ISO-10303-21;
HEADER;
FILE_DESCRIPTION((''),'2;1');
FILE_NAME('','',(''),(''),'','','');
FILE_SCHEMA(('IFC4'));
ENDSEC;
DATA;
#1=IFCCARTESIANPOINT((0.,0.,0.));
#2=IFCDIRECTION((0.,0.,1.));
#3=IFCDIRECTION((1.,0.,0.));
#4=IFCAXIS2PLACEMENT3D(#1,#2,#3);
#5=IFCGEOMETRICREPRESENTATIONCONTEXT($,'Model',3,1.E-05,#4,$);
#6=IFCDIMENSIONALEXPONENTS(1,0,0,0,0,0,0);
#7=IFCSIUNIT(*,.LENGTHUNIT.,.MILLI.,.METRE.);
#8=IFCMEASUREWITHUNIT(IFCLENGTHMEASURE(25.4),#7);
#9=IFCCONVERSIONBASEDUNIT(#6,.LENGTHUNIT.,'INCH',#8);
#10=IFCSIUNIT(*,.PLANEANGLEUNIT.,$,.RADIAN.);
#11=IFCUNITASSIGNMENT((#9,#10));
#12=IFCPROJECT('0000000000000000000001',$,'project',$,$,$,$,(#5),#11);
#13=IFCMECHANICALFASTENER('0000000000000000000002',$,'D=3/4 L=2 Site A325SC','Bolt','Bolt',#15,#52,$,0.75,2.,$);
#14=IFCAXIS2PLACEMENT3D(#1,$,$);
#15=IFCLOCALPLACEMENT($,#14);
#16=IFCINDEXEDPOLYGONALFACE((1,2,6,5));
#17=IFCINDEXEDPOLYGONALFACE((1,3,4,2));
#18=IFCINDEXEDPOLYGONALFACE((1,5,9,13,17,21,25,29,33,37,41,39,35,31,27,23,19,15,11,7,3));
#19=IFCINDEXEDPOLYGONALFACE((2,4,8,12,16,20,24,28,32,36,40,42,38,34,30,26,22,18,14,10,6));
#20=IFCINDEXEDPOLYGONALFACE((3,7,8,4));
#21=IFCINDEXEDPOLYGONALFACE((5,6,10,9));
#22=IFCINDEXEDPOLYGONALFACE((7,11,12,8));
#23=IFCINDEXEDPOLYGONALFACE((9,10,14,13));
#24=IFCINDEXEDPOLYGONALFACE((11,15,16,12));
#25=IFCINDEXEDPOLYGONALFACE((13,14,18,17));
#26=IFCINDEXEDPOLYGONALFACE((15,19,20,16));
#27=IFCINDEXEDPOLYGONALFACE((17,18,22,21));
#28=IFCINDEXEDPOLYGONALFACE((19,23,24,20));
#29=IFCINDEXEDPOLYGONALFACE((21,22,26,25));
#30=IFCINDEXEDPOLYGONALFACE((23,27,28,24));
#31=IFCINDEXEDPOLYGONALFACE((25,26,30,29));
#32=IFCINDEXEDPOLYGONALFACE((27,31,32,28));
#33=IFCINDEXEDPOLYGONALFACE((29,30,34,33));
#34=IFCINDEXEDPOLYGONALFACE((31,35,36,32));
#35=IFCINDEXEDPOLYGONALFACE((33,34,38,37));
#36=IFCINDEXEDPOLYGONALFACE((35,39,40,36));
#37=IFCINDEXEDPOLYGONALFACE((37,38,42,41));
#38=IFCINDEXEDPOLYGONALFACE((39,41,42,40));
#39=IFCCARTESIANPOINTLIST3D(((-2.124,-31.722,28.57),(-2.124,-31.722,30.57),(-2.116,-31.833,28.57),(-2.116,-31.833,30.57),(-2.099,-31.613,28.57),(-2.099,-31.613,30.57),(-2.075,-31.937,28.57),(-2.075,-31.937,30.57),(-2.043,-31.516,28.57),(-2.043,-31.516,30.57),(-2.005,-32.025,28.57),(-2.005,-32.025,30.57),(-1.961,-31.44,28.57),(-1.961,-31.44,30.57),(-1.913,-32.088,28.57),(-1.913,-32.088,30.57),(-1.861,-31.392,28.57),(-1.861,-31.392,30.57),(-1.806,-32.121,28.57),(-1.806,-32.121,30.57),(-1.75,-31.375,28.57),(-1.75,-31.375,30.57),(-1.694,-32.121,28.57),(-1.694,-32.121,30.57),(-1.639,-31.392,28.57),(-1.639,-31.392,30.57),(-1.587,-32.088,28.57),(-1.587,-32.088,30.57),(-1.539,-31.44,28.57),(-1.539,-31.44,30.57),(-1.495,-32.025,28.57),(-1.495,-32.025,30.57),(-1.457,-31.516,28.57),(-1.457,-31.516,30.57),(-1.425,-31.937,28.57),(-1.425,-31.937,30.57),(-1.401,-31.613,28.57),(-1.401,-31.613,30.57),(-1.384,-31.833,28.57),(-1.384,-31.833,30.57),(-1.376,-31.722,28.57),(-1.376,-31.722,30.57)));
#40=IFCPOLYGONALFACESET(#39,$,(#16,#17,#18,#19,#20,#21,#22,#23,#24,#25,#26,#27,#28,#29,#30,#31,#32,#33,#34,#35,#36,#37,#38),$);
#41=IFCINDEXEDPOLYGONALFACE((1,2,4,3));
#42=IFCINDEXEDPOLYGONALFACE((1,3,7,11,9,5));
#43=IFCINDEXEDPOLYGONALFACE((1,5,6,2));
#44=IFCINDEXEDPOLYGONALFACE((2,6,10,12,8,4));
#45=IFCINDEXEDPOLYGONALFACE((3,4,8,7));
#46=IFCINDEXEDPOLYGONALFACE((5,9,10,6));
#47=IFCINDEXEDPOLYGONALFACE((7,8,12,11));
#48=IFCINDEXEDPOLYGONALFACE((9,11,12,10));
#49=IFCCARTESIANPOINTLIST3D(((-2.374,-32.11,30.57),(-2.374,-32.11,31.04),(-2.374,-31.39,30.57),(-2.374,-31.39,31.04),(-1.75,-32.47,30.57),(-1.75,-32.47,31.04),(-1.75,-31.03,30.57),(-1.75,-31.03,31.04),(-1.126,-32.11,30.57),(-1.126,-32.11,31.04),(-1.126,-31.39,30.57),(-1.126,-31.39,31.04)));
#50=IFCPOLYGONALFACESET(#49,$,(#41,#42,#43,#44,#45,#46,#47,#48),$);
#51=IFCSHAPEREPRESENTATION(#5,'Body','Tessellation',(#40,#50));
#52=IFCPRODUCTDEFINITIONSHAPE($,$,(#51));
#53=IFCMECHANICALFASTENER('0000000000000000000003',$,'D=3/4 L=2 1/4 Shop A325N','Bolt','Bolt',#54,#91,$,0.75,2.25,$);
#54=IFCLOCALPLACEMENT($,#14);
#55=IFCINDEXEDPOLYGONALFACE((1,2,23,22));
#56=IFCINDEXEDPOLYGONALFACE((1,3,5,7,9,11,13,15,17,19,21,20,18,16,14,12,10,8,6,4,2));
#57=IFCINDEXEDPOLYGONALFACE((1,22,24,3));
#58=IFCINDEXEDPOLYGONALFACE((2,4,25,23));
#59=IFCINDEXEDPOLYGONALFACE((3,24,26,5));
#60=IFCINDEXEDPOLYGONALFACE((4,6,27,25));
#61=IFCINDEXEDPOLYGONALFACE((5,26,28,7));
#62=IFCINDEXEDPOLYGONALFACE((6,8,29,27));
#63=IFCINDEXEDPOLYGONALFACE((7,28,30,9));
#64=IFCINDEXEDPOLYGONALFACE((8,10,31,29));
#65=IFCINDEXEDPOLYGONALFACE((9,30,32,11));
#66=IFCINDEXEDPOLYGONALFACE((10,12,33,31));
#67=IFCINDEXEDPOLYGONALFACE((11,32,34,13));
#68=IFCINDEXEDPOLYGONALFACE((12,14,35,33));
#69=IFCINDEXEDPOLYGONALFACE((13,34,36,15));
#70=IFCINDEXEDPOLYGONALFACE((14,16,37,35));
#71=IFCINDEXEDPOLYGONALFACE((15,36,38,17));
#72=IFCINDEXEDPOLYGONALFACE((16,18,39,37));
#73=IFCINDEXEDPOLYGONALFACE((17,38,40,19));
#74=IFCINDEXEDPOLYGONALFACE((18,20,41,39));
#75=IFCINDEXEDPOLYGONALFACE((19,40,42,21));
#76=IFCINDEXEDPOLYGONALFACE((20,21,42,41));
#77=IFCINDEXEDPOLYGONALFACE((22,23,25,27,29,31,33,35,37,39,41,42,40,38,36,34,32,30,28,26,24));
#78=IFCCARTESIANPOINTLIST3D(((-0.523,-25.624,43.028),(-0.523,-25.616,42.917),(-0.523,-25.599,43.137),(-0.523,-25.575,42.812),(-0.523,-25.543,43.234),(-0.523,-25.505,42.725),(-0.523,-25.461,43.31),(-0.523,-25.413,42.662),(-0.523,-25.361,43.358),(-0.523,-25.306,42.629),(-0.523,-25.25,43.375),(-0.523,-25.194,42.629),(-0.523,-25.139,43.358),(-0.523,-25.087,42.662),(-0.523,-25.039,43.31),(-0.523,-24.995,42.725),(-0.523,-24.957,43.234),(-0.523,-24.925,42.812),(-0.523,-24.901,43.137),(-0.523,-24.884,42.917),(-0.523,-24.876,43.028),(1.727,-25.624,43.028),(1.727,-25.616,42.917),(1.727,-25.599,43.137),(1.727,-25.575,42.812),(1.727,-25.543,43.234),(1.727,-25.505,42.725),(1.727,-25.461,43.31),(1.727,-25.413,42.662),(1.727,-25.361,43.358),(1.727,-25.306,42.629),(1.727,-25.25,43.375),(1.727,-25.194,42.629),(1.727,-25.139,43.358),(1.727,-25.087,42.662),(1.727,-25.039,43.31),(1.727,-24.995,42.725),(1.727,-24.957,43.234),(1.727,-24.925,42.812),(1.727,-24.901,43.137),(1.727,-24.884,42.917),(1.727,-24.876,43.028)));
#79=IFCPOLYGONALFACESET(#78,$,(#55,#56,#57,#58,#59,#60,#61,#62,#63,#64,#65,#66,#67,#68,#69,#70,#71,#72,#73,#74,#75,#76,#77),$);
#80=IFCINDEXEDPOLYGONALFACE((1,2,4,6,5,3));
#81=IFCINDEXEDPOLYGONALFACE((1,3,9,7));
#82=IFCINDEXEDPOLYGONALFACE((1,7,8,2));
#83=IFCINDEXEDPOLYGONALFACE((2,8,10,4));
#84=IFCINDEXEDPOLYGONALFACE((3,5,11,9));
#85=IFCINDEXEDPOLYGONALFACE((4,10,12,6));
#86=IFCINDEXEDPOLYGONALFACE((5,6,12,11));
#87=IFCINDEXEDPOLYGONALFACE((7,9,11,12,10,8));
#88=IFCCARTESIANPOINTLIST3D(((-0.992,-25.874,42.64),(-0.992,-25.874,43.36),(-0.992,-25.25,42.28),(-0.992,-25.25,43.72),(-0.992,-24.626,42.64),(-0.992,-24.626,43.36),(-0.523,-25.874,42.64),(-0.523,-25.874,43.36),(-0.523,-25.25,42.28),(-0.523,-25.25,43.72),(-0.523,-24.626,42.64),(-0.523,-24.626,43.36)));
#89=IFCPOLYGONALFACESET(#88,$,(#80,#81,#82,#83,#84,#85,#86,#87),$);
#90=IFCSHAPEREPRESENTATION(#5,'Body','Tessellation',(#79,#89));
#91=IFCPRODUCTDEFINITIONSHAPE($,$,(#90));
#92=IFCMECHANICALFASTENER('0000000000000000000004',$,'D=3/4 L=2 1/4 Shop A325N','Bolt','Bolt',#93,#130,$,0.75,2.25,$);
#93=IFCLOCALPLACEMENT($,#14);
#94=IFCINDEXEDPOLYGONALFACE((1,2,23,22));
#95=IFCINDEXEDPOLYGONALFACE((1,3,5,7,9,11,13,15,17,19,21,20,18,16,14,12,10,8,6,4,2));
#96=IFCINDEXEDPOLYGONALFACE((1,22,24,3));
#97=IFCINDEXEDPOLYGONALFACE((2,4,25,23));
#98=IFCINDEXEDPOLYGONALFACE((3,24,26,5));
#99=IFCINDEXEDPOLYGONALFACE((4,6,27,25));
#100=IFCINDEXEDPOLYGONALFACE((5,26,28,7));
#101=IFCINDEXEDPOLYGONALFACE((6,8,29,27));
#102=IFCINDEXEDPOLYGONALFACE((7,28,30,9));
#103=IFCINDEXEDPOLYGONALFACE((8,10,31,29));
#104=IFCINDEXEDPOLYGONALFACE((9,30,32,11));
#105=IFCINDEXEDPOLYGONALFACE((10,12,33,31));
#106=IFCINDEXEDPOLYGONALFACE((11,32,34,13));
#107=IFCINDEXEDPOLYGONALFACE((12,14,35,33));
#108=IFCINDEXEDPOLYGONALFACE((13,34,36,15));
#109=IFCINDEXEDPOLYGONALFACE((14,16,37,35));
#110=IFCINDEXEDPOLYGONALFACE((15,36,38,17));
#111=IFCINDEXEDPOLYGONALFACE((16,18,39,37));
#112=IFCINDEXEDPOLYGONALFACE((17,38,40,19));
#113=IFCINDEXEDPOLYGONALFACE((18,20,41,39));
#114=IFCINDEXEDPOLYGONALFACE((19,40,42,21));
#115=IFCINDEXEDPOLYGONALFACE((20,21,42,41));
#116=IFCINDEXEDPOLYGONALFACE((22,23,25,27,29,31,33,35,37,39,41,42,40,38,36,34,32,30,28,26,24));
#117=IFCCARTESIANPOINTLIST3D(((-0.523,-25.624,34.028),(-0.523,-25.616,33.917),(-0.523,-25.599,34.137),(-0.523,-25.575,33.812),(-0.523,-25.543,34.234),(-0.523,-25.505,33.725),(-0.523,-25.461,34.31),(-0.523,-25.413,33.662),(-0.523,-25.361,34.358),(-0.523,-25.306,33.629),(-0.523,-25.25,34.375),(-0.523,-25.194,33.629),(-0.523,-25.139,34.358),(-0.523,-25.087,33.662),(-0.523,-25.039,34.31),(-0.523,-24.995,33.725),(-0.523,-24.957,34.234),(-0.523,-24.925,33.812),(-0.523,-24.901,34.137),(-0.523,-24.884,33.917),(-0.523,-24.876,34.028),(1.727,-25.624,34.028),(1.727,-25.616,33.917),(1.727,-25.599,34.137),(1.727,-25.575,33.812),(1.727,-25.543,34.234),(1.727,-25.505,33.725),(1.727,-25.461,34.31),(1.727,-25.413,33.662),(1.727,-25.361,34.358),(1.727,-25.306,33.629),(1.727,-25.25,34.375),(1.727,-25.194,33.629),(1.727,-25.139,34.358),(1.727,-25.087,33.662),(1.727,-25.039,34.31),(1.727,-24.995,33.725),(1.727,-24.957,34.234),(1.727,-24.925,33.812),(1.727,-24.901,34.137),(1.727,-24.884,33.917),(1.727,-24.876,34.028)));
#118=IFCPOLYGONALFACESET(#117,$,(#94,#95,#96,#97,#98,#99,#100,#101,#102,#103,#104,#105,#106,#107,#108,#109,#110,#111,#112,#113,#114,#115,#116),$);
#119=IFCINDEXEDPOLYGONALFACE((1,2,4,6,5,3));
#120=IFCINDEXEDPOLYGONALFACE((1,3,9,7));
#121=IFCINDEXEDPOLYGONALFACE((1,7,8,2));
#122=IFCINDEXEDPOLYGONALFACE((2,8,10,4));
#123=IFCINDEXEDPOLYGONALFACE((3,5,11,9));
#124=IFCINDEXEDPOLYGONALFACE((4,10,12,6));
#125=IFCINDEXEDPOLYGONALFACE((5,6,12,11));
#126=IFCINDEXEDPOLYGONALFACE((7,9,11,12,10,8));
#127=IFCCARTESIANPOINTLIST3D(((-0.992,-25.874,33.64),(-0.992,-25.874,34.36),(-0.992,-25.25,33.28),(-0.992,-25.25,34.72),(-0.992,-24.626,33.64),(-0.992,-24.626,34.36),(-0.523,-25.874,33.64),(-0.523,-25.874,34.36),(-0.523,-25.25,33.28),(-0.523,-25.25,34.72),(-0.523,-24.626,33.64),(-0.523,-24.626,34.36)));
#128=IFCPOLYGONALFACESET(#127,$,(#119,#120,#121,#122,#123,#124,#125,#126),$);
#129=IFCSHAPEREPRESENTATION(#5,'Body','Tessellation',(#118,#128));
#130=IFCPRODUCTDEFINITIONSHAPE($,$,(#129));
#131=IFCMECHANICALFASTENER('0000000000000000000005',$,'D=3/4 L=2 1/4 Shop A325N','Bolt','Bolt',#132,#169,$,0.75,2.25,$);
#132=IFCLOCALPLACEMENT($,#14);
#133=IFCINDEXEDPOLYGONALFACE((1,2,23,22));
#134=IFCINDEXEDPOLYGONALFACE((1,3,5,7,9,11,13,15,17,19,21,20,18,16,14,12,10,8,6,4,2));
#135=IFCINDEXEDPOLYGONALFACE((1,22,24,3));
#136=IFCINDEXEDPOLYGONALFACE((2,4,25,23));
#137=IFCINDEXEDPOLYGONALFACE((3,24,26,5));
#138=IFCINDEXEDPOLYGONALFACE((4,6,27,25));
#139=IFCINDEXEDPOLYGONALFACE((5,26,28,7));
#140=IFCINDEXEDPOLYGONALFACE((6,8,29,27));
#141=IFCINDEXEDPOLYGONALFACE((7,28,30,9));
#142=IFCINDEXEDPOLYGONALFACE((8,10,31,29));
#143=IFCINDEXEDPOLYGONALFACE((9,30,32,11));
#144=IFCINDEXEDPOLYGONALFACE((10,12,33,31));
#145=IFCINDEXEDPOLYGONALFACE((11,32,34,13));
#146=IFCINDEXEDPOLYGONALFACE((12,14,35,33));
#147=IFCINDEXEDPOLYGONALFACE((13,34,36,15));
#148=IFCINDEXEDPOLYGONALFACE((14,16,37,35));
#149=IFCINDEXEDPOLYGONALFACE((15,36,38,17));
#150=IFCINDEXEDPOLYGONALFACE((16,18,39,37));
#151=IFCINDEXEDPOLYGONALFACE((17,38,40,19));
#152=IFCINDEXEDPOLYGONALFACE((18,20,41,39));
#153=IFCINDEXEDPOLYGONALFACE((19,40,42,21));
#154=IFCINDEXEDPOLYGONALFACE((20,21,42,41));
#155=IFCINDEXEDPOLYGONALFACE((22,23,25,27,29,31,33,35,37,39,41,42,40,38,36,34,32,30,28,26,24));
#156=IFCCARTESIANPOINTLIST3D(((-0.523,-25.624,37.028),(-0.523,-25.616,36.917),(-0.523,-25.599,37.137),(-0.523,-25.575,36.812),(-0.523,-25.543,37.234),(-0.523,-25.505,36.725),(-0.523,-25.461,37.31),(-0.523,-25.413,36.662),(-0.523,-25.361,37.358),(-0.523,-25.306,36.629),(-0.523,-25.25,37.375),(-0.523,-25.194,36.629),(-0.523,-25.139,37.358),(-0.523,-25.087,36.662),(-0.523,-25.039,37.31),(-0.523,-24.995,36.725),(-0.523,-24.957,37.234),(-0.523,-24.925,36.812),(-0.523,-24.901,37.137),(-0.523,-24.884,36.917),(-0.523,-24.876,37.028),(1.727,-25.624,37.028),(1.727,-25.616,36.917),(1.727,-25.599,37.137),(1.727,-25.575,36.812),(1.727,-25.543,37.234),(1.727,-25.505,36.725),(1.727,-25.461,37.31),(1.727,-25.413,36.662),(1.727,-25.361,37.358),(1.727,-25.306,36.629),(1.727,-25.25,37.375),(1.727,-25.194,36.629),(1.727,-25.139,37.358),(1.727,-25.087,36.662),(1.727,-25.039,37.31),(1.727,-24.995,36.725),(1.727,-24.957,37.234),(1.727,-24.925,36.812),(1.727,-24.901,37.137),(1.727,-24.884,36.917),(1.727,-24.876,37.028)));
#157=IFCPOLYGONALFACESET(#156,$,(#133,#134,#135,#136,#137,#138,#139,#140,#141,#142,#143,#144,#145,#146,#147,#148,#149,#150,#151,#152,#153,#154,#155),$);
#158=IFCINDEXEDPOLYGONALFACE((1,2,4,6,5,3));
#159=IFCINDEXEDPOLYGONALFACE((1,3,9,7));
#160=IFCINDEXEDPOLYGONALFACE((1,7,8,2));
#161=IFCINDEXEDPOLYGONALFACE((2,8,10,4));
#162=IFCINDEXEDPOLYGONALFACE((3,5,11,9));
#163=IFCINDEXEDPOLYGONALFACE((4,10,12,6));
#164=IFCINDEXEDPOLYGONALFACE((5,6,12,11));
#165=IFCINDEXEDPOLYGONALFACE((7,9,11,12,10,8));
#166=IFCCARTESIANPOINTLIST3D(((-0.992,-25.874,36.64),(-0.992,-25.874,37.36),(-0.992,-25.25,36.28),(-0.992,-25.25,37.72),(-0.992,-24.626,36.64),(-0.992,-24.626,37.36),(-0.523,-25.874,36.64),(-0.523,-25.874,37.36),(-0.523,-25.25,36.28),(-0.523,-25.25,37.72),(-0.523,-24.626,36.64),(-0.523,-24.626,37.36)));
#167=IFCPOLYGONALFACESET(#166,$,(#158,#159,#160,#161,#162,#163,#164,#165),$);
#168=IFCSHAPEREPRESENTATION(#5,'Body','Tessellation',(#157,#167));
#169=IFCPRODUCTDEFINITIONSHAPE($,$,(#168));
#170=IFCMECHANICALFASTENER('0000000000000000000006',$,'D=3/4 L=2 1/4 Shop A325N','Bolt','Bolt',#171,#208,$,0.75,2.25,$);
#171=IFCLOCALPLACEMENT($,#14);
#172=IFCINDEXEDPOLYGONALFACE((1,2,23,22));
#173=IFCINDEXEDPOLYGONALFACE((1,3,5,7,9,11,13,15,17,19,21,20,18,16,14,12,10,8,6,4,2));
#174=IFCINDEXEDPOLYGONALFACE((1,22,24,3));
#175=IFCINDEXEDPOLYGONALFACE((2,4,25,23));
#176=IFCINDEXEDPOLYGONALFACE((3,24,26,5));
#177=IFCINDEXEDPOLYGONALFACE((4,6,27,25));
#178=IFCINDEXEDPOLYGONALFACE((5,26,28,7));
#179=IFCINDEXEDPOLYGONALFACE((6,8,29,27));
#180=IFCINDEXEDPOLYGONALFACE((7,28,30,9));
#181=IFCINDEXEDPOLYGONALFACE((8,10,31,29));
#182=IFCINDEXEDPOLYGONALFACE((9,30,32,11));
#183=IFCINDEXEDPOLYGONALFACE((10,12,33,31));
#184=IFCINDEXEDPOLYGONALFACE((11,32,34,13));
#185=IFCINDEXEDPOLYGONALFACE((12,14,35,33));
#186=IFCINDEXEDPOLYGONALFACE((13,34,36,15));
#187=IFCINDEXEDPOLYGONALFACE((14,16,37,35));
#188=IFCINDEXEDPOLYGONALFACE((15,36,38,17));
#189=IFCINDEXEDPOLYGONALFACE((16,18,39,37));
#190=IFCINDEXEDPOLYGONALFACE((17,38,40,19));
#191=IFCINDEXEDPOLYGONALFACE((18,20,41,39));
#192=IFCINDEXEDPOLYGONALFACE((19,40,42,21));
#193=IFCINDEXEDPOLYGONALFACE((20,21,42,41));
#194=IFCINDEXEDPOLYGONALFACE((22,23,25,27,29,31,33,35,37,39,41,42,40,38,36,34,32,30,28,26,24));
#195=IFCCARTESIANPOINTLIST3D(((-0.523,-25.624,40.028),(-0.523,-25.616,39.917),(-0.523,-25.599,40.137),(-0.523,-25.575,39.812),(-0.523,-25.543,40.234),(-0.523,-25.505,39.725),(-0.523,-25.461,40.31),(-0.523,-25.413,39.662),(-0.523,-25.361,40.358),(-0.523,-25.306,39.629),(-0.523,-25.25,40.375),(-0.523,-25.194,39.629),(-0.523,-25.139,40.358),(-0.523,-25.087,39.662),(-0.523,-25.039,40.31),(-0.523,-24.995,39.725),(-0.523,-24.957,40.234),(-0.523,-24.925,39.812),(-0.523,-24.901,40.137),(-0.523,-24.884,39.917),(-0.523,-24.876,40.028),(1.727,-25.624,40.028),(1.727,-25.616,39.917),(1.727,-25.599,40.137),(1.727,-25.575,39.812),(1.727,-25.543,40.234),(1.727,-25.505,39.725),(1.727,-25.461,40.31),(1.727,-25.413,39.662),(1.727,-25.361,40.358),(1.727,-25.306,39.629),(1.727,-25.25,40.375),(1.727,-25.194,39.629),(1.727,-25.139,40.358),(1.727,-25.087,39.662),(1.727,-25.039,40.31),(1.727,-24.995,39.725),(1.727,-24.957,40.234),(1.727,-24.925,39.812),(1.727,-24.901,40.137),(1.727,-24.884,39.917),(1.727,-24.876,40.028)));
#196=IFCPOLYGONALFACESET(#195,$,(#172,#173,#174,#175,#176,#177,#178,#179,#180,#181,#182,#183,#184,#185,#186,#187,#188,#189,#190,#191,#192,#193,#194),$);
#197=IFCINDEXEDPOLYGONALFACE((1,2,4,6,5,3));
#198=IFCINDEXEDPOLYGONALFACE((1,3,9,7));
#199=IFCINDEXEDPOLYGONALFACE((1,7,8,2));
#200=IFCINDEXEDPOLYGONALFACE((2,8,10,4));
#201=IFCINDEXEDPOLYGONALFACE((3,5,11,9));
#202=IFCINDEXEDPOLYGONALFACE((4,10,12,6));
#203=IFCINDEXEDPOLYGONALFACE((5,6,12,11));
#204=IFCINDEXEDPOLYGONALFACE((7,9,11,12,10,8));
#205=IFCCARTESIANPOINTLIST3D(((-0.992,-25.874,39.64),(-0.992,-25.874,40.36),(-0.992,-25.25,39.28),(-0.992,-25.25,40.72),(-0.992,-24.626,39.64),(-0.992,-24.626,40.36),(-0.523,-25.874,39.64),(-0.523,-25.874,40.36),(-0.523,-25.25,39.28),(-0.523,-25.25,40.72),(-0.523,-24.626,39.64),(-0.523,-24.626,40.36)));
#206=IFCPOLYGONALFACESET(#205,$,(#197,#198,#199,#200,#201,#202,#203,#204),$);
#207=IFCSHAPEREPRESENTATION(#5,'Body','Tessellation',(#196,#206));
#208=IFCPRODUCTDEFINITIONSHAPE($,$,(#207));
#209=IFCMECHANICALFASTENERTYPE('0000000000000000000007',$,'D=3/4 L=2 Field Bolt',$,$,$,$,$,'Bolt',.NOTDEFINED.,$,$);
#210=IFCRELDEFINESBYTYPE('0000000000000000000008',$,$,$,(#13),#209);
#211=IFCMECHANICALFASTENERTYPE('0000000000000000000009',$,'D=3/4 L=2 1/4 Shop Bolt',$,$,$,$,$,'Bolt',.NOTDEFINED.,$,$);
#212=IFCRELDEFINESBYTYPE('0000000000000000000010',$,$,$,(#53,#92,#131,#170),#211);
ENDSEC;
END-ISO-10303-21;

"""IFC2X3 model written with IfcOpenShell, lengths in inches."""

from ifc_helpers import new_model, entity, si_unit, converted_unit, frame, origin_with_axes, origin_2d_with_axis, place, context, project, polyline, circle, outline, extrude, source, transform, mapped, type_object, type_shapes, element, save


model = new_model("IFC2X3")

# Units and contexts
model_context = context("Model", 3, precision=1e-05, world=origin_with_axes())
ifc_project = project(units=[converted_unit("LENGTHUNIT", "INCH", entity("IfcLengthMeasure", 25.4), si_unit("LENGTHUNIT", "METRE", prefix="MILLI"), dimensions=[1, 0, 0, 0, 0, 0, 0]), si_unit("PLANEANGLEUNIT", "RADIAN")], contexts=[model_context])

# Mechanical fasteners
placement_1 = place(None, origin_with_axes())
placement_2 = place(placement_1, origin_with_axes())
placement_3 = place(placement_2, frame((0.0, 0.0, 46.0), z_axis=(0.0, 0.0, 1.0), x_axis=(0.0, -1.0, 0.0)))
mechanical_fastener_type_1 = type_object("IfcMechanicalFastenerType", Name="D=3/4 L=2 Field Bolt", ElementType="Bolt")
shared_shape_1 = source(origin_with_axes(), model_context, "Body", "SweptSolid", [
    extrude(circle(Radius=0.375, at=origin_2d_with_axis()), frame((0.0, 0.0, 0.0), z_axis=(1.0, 0.0, 0.0), x_axis=(0.0, 1.0, 0.0)), (0.0, 0.0, 1.0), 2.0),
    extrude(outline(polyline([(-0.72, 0.0), (-0.36, 0.624), (0.36, 0.624), (0.72, 0.0), (0.36, -0.624), (-0.36, -0.624), (-0.72, 0.0)])), frame((0.0, 0.0, 0.0), z_axis=(1.0, 0.0, 0.0), x_axis=(0.0, 1.0, 0.0)), (0.0, 0.0, -1.0), 0.47),
])
type_shapes(mechanical_fastener_type_1, [shared_shape_1])
placement_4 = place(placement_3, frame((28.75, -1.75, -15.43), z_axis=(0.0, 1.0, 0.0), x_axis=(0.0, 0.0, -1.0)))
for number, where, z_axis, x_axis, name in (
    (1, (0.0, -3.0, 0.0), (0.0, 0.0, 1.0), (1.0, 0.0, 0.0), "D=3/4 L=2 Site A325SC"),
):
    element("IfcMechanicalFastener", number, at=place(placement_4, frame(where, z_axis=z_axis, x_axis=x_axis)), type_object=mechanical_fastener_type_1, Name=name, Description="Bolt", ObjectType="Bolt", NominalDiameter=0.75, NominalLength=2.0, context=model_context, shape_type="MappedRepresentation", body=[
        mapped(shared_shape_1, transform((0.0, 0.0, 0.0), scale=1.0)),
    ])
mechanical_fastener_type_2 = type_object("IfcMechanicalFastenerType", Name="D=3/4 L=2 1/4 Shop Bolt", ElementType="Bolt")
shared_shape_2 = source(origin_with_axes(), model_context, "Body", "SweptSolid", [
    extrude(circle(Radius=0.375, at=origin_2d_with_axis()), frame((0.0, 0.0, 0.0), z_axis=(1.0, 0.0, 0.0), x_axis=(0.0, 1.0, 0.0)), (0.0, 0.0, 1.0), 2.25),
    extrude(outline(polyline([(-0.72, 0.0), (-0.36, 0.624), (0.36, 0.624), (0.72, 0.0), (0.36, -0.624), (-0.36, -0.624), (-0.72, 0.0)])), frame((0.0, 0.0, 0.0), z_axis=(1.0, 0.0, 0.0), x_axis=(0.0, 1.0, 0.0)), (0.0, 0.0, -1.0), 0.47),
])
type_shapes(mechanical_fastener_type_2, [shared_shape_2])
placement_5 = place(placement_3, frame((25.25, -0.523, -3.0), z_axis=(1.0, 0.0, 0.0), x_axis=(0.0, 1.0, 0.0)))
for number, where, z_axis, x_axis, name in (
    (2, (0.0, 0.0, 0.0), (0.0, 0.0, 1.0), (1.0, 0.0, 0.0), "D=3/4 L=2 1/4 Shop A325N"),
    (3, (0.0, -9.0, 0.0), (0.0, 0.0, 1.0), (1.0, 0.0, 0.0), "D=3/4 L=2 1/4 Shop A325N"),
    (4, (0.0, -6.0, 0.0), (0.0, 0.0, 1.0), (1.0, 0.0, 0.0), "D=3/4 L=2 1/4 Shop A325N"),
    (5, (0.0, -3.0, 0.0), (0.0, 0.0, 1.0), (1.0, 0.0, 0.0), "D=3/4 L=2 1/4 Shop A325N"),
):
    element("IfcMechanicalFastener", number, at=place(placement_5, frame(where, z_axis=z_axis, x_axis=x_axis)), type_object=mechanical_fastener_type_2, Name=name, Description="Bolt", ObjectType="Bolt", NominalDiameter=0.75, NominalLength=2.25, context=model_context, shape_type="MappedRepresentation", body=[
        mapped(shared_shape_2, transform((0.0, 0.0, 0.0), scale=1.0)),
    ])

save(model, "model.ifc")
